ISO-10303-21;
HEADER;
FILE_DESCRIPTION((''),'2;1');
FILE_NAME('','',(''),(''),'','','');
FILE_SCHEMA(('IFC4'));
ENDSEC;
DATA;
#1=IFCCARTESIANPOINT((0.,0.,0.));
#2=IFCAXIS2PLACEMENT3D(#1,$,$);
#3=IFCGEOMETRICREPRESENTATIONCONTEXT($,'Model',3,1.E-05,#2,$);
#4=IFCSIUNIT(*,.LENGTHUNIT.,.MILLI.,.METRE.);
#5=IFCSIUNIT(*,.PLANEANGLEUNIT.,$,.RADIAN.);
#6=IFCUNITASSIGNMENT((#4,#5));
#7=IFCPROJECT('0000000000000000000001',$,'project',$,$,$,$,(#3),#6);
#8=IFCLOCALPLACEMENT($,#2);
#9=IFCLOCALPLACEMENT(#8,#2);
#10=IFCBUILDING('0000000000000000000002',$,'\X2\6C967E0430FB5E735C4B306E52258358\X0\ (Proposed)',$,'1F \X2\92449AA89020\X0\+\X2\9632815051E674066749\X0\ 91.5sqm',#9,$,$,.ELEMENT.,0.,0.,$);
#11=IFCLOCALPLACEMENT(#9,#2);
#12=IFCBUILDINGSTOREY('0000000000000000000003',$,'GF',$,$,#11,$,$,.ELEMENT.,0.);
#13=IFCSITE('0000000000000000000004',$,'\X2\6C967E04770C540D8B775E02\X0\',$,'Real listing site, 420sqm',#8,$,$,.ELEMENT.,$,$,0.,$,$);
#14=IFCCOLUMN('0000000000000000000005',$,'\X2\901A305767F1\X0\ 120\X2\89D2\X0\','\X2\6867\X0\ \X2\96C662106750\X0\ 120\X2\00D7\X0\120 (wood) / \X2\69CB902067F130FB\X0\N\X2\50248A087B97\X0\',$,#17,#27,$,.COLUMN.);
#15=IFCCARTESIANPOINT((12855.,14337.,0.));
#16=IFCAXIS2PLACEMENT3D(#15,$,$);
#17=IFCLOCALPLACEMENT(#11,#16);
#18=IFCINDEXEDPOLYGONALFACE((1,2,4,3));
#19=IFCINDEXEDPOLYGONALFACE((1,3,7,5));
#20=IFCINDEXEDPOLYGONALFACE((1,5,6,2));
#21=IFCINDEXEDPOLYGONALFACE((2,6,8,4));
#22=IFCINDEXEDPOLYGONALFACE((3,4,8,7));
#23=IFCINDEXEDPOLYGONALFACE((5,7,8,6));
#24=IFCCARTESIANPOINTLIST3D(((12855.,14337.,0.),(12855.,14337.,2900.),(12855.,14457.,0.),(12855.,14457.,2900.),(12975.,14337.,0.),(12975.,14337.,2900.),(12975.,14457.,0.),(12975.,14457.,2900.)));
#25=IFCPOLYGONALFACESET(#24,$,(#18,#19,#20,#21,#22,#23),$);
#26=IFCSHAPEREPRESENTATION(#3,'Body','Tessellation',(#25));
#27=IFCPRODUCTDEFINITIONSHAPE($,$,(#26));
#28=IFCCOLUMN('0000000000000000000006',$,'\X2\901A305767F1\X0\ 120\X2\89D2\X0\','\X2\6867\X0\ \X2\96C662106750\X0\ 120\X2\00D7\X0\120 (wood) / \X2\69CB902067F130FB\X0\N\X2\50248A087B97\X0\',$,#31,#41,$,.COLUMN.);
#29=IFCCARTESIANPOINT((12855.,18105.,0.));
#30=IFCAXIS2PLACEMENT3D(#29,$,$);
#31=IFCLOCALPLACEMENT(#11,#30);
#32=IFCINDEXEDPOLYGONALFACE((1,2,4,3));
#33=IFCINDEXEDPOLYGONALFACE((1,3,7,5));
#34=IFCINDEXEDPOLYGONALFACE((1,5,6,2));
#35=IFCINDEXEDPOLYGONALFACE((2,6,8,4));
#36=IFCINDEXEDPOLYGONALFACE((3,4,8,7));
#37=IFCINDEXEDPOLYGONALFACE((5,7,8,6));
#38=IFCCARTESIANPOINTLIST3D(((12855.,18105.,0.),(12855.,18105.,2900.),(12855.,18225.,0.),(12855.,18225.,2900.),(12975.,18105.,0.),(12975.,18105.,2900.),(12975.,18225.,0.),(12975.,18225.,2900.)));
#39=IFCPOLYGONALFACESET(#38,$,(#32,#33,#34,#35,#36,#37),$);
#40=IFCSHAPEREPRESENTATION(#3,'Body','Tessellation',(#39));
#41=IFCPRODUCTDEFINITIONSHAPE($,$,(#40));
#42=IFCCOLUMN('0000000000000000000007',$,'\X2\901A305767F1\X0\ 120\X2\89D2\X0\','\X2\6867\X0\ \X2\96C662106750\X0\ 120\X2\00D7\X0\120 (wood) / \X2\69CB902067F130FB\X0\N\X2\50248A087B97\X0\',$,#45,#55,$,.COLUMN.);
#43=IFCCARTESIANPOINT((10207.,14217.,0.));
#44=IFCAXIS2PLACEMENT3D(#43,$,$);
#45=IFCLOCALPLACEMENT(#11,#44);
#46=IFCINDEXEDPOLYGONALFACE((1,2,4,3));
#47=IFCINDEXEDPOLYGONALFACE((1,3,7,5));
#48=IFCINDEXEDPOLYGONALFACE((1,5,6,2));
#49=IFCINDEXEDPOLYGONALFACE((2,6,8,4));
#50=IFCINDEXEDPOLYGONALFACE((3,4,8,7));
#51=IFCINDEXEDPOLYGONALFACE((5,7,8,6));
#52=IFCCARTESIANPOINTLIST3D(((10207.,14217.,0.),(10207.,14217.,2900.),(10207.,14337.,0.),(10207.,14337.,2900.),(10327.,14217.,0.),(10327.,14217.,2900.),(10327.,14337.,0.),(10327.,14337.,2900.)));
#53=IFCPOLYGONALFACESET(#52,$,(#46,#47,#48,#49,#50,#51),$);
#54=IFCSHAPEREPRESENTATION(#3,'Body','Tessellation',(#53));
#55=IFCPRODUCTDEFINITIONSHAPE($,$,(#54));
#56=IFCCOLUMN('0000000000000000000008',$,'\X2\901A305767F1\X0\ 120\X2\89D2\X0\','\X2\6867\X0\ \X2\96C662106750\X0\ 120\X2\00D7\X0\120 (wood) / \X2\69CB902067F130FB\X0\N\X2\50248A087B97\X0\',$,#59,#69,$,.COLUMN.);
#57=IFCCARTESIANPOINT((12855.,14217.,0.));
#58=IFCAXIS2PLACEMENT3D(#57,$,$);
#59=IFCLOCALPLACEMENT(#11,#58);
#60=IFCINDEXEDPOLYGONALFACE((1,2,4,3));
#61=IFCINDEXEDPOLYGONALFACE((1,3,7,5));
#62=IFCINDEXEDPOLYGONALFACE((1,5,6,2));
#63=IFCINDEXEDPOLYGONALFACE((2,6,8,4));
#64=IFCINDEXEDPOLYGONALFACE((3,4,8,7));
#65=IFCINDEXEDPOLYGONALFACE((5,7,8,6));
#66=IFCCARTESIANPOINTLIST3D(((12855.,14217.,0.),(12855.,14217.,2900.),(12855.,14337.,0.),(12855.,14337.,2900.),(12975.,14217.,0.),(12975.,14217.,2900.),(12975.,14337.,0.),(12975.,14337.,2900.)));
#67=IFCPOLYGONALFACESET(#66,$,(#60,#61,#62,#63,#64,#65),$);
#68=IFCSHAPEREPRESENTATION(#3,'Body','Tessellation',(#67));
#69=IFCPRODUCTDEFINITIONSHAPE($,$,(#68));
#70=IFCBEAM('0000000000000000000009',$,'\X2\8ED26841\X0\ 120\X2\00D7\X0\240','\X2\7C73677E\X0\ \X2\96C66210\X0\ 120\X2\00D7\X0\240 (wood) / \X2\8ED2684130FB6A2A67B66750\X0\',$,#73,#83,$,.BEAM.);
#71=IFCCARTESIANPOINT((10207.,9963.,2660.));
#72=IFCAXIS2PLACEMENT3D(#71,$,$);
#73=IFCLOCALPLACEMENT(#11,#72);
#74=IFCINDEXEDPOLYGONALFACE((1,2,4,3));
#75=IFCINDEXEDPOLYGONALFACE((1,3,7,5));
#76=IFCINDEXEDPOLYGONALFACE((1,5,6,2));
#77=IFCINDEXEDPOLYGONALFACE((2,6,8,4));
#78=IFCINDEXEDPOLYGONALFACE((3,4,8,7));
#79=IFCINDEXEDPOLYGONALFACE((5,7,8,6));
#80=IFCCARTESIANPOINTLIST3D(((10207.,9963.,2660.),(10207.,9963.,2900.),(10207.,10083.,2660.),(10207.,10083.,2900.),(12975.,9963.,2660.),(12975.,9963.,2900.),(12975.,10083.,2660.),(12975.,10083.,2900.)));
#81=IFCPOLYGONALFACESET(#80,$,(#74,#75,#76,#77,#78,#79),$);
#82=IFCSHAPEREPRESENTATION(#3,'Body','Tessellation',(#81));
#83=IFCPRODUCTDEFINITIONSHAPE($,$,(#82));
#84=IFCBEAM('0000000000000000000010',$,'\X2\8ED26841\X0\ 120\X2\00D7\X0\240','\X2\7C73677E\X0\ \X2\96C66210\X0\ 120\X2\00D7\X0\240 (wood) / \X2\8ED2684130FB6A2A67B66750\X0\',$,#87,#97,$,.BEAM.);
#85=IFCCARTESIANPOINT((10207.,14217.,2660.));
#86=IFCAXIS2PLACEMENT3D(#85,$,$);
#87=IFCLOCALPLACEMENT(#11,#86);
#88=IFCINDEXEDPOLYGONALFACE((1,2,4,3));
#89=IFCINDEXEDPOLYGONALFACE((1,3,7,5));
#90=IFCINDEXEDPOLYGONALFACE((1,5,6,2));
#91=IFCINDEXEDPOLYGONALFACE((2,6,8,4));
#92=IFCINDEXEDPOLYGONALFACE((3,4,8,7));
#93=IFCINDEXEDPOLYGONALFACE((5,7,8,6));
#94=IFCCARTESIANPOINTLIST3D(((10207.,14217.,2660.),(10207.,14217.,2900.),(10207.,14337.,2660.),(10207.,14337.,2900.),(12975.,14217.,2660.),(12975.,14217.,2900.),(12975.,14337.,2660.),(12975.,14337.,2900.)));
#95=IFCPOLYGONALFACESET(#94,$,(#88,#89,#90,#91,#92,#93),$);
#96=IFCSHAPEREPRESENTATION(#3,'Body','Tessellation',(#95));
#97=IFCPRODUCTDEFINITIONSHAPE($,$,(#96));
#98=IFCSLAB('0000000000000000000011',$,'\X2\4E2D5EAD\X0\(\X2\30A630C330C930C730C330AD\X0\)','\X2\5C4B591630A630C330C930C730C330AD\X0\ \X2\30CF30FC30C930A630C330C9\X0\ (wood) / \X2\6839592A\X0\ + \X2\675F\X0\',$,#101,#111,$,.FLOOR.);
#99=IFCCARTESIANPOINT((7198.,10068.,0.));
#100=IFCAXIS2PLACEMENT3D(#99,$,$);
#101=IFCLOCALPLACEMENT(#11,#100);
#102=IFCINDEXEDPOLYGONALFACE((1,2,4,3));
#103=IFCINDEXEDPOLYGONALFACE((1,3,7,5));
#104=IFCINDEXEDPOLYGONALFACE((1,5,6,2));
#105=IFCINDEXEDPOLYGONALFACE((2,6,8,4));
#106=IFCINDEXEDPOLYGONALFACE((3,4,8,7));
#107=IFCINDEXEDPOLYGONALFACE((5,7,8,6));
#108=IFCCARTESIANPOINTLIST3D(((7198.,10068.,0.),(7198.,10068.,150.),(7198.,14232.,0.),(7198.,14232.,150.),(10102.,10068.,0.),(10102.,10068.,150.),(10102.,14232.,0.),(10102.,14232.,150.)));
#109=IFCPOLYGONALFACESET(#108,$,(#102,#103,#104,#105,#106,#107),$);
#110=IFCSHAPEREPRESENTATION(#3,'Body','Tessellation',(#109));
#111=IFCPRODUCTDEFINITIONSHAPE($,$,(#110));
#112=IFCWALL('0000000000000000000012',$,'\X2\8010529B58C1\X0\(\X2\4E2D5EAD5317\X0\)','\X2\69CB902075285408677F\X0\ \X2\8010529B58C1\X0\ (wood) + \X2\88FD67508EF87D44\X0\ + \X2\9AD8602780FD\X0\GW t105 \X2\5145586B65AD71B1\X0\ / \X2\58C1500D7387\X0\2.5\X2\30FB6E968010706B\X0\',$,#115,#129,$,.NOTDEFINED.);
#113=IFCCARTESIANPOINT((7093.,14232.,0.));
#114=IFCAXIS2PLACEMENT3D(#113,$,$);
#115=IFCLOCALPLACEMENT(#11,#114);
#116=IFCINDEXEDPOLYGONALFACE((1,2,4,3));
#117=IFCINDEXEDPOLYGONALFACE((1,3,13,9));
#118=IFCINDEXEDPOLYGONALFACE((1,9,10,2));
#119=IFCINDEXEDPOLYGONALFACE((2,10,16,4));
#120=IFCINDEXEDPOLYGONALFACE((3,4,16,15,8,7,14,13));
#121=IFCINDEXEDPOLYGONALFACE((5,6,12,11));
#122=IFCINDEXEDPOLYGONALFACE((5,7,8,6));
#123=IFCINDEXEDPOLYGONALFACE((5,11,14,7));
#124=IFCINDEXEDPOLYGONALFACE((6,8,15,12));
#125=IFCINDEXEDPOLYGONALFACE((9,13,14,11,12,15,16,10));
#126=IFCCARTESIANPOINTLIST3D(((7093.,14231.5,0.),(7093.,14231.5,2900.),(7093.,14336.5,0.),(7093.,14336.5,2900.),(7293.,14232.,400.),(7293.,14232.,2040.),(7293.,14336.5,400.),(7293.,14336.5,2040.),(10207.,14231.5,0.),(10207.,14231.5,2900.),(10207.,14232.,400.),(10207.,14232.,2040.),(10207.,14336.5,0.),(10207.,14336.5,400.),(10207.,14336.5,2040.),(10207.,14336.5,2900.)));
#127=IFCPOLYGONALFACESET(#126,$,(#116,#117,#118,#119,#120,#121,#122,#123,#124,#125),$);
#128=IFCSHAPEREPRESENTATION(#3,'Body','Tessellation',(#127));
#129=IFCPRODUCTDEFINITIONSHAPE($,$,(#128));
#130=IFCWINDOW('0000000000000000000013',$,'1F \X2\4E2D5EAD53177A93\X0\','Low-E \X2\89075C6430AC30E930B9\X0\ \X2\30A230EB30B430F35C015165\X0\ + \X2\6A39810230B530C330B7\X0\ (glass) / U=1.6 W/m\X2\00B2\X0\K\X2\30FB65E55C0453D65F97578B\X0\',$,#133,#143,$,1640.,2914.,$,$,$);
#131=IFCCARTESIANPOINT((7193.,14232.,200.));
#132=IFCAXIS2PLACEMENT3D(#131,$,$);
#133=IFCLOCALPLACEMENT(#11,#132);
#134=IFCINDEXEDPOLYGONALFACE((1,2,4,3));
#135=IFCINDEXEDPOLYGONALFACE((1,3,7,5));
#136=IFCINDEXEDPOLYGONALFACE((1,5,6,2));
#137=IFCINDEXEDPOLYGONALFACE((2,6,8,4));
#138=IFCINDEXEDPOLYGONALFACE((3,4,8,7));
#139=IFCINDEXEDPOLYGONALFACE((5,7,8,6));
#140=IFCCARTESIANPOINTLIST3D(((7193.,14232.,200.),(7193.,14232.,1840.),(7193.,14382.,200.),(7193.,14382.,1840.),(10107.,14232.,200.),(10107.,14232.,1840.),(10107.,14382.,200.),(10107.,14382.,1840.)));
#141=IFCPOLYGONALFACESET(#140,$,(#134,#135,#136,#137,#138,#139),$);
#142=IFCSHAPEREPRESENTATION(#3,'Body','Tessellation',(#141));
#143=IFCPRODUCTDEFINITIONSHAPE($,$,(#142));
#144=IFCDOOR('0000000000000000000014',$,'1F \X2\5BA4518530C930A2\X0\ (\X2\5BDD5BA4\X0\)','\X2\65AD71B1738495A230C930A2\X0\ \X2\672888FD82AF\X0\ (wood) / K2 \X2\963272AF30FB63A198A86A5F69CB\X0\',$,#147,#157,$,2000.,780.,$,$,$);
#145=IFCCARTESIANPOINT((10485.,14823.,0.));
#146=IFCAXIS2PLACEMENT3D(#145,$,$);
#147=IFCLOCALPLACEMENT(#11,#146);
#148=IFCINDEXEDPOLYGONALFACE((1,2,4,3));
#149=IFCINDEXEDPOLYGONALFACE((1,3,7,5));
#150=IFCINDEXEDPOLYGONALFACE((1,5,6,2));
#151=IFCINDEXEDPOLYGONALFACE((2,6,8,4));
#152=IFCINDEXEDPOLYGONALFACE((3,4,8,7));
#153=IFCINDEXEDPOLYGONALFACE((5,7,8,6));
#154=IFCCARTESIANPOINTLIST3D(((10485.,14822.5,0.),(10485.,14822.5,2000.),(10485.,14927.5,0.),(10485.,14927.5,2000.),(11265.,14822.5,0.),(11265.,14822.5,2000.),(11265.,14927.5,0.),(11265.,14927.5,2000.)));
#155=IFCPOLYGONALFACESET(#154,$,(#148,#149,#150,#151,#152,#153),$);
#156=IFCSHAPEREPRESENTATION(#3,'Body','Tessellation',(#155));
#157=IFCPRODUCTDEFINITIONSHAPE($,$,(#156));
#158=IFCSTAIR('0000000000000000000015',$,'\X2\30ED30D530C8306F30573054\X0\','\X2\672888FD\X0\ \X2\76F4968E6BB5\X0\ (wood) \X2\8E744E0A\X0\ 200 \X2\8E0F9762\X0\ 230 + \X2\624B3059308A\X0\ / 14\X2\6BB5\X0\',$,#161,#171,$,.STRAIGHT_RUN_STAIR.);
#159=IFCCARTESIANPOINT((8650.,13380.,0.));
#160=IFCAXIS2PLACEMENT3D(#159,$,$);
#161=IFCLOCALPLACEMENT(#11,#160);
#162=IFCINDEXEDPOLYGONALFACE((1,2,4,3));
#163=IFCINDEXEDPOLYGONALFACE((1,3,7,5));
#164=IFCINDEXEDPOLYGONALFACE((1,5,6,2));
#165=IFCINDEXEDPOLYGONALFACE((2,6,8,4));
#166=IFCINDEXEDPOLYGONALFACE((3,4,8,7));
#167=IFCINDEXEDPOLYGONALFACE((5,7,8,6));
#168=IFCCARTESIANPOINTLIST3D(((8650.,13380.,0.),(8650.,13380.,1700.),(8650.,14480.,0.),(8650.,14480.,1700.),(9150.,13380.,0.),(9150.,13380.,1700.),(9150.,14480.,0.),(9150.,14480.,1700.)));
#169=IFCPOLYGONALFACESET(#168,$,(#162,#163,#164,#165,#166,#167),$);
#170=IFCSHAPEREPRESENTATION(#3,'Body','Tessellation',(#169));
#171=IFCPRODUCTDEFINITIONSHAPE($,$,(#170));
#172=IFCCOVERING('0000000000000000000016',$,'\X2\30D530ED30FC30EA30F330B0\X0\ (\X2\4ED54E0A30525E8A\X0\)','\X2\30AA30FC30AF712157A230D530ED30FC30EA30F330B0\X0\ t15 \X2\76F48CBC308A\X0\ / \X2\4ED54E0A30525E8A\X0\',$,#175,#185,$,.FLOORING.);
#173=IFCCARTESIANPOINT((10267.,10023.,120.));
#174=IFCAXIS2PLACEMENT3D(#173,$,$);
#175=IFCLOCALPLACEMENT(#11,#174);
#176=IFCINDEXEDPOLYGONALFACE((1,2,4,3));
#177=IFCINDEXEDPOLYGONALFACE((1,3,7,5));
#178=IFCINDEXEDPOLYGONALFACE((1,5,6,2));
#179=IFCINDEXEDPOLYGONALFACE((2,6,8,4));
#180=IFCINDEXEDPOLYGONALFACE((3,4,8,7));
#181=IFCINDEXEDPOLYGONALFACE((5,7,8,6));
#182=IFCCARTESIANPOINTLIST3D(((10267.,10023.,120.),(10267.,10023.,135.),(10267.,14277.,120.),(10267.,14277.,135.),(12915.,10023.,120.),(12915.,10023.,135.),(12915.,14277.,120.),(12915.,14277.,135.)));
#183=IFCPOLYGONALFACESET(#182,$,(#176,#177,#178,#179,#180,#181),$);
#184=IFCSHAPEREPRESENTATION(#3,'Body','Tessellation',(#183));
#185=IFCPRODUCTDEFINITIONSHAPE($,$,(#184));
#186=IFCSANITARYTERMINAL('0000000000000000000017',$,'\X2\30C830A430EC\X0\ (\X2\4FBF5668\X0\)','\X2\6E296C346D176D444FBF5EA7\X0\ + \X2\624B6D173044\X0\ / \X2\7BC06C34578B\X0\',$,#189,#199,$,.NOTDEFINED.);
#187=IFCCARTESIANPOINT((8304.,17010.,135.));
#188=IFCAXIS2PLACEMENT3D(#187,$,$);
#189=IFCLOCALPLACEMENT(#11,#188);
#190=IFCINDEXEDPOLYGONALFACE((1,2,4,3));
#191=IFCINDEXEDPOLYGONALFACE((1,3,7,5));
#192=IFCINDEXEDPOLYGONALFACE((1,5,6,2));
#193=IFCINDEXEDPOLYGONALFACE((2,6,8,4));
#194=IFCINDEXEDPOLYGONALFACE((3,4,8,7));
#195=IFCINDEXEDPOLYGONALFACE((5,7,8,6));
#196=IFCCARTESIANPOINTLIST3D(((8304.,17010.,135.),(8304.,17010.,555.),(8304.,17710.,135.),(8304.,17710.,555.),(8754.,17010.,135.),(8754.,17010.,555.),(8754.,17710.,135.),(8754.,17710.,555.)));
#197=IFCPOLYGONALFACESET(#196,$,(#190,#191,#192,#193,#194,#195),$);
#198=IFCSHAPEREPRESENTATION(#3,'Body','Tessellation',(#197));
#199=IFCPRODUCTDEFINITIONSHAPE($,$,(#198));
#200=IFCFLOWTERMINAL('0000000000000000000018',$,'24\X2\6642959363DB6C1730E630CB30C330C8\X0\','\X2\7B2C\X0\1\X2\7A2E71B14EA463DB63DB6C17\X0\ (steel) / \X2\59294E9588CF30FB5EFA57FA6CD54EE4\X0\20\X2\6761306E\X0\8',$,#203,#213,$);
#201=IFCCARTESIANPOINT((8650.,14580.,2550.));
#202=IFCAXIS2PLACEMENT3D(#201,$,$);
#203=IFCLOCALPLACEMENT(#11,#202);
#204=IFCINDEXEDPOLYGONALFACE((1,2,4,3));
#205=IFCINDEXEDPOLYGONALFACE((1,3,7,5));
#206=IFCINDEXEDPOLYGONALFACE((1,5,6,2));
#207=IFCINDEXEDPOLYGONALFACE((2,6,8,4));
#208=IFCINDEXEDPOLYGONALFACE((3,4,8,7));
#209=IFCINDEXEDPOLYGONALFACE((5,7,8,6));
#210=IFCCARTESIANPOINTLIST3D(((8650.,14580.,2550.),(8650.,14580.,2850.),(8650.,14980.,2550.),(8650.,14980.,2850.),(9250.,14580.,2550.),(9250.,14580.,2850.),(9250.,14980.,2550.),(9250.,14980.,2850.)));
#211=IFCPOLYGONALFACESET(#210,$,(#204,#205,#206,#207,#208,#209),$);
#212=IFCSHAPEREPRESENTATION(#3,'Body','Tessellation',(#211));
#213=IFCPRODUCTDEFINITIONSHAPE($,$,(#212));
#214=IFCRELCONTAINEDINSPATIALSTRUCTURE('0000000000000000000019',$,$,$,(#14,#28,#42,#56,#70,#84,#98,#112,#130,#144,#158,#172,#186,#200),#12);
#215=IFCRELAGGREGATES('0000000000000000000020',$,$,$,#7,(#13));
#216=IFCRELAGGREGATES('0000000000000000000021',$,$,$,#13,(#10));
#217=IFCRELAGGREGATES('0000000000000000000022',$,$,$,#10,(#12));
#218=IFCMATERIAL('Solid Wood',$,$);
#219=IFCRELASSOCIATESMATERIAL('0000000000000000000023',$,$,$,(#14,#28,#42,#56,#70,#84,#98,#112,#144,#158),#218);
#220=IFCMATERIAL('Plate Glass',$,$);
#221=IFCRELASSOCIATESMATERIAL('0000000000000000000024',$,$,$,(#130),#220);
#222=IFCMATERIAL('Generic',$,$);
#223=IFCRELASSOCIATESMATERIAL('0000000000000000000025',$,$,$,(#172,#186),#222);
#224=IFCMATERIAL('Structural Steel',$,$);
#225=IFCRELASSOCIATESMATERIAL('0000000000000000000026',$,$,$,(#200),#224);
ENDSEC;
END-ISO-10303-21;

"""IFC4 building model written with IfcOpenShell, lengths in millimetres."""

from ifc_helpers import new_model, si_unit, frame, frame_2d, origin, place, context, project, spatial, rectangle, extrude, material, element, fill, save


model = new_model("IFC4")

# Units and contexts
model_context = context("Model", 3, precision=1e-05, world=origin())
ifc_project = project(units=[si_unit("LENGTHUNIT", "METRE", prefix="MILLI"), si_unit("PLANEANGLEUNIT", "RADIAN")], contexts=[model_context])

# Site, building, storey
site_placement = place(None, origin())
site = spatial("IfcSite", under=ifc_project, at=site_placement, Name="沖縄県名護市", ObjectType="Real listing site, 420sqm", CompositionType="ELEMENT", RefElevation=0.0)
building_placement = place(site_placement, origin())
building = spatial("IfcBuilding", under=site, at=building_placement, Name="沖縄・平屋の別荘 (Proposed)", ObjectType="1F 鉄骨造+防腐処理杉 91.5sqm", CompositionType="ELEMENT", ElevationOfRefHeight=0.0, ElevationOfTerrain=0.0)
storey_placement = place(building_placement, origin())
storey = spatial("IfcBuildingStorey", under=building, at=storey_placement, Name="GF", CompositionType="ELEMENT", Elevation=0.0)

# Columns
ifc_material_1 = material(Name="Solid Wood")
column_1_placement = place(storey_placement, frame((12855.0, 14337.0, 0.0)))
element("IfcColumn", 1, at=column_1_placement, inside=storey, material=ifc_material_1, Name="通し柱 120角", Description="桧 集成材 120×120 (wood) / 構造柱・N値計算", PredefinedType="COLUMN", context=model_context, shape_type="SweptSolid", body=[
    extrude(rectangle(XDim=120.0, YDim=120.0, at=frame_2d((60.0, 60.0))), frame((12855.0, 14337.0, 0.0)), (0.0, 0.0, 1.0), 2900.0),
])
column_2_placement = place(storey_placement, frame((12855.0, 18105.0, 0.0)))
element("IfcColumn", 2, at=column_2_placement, inside=storey, material=ifc_material_1, Name="通し柱 120角", Description="桧 集成材 120×120 (wood) / 構造柱・N値計算", PredefinedType="COLUMN", context=model_context, shape_type="SweptSolid", body=[
    extrude(rectangle(XDim=120.0, YDim=120.0, at=frame_2d((60.0, 60.0))), frame((12855.0, 18105.0, 0.0)), (0.0, 0.0, 1.0), 2900.0),
])
column_3_placement = place(storey_placement, frame((10207.0, 14217.0, 0.0)))
element("IfcColumn", 3, at=column_3_placement, inside=storey, material=ifc_material_1, Name="通し柱 120角", Description="桧 集成材 120×120 (wood) / 構造柱・N値計算", PredefinedType="COLUMN", context=model_context, shape_type="SweptSolid", body=[
    extrude(rectangle(XDim=120.0, YDim=120.0, at=frame_2d((60.0, 60.0))), frame((10207.0, 14217.0, 0.0)), (0.0, 0.0, 1.0), 2900.0),
])
column_4_placement = place(storey_placement, frame((12855.0, 14217.0, 0.0)))
element("IfcColumn", 4, at=column_4_placement, inside=storey, material=ifc_material_1, Name="通し柱 120角", Description="桧 集成材 120×120 (wood) / 構造柱・N値計算", PredefinedType="COLUMN", context=model_context, shape_type="SweptSolid", body=[
    extrude(rectangle(XDim=120.0, YDim=120.0, at=frame_2d((60.0, 60.0))), frame((12855.0, 14217.0, 0.0)), (0.0, 0.0, 1.0), 2900.0),
])

# Beams
beam_1_placement = place(storey_placement, frame((10207.0, 9963.0, 2660.0)))
element("IfcBeam", 5, at=beam_1_placement, inside=storey, material=ifc_material_1, Name="軒桁 120×240", Description="米松 集成 120×240 (wood) / 軒桁・横架材", PredefinedType="BEAM", context=model_context, shape_type="SweptSolid", body=[
    extrude(rectangle(XDim=2768.0, YDim=120.0, at=frame_2d((1384.0, 60.0))), frame((10207.0, 9963.0, 2660.0)), (0.0, 0.0, 1.0), 240.0),
])
beam_2_placement = place(storey_placement, frame((10207.0, 14217.0, 2660.0)))
element("IfcBeam", 6, at=beam_2_placement, inside=storey, material=ifc_material_1, Name="軒桁 120×240", Description="米松 集成 120×240 (wood) / 軒桁・横架材", PredefinedType="BEAM", context=model_context, shape_type="SweptSolid", body=[
    extrude(rectangle(XDim=2768.0, YDim=120.0, at=frame_2d((1384.0, 60.0))), frame((10207.0, 14217.0, 2660.0)), (0.0, 0.0, 1.0), 240.0),
])

# Slab
slab_placement = place(storey_placement, frame((7198.0, 10068.0, 0.0)))
element("IfcSlab", 7, at=slab_placement, inside=storey, material=ifc_material_1, Name="中庭(ウッドデッキ)", Description="屋外ウッドデッキ ハードウッド (wood) / 根太 + 束", PredefinedType="FLOOR", context=model_context, shape_type="SweptSolid", body=[
    extrude(rectangle(XDim=2904.0, YDim=4164.0, at=frame_2d((1452.0, 2082.0))), frame((7198.0, 10068.0, 0.0)), (0.0, 0.0, 1.0), 150.0),
])

# Wall, opening, window
wall_1_placement = place(storey_placement, frame((7093.0, 14232.0, 0.0)))
wall_1 = element("IfcWall", 8, at=wall_1_placement, inside=storey, material=ifc_material_1, Name="耐力壁(中庭北)", Description="構造用合板 耐力壁 (wood) + 製材軸組 + 高性能GW t105 充填断熱 / 壁倍率2.5・準耐火", PredefinedType="NOTDEFINED", context=model_context, shape_type="SweptSolid", body=[
    extrude(rectangle(XDim=3114.0, YDim=105.0, at=frame_2d((1557.0, 52.0))), frame((7093.0, 14232.0, 0.0)), (0.0, 0.0, 1.0), 2900.0),
])
opening_placement = place(storey_placement, frame((7193.0, 14232.0, 200.0)))
opening = element("IfcOpeningElement", 9, at=opening_placement, cuts=wall_1, PredefinedType="NOTDEFINED", context=model_context, shape_type="SweptSolid", body=[
    extrude(rectangle(XDim=2914.0, YDim=150.0, at=frame_2d((1457.0, 75.0))), frame((7193.0, 14232.0, 200.0)), (0.0, 0.0, 1.0), 1640.0),
])
ifc_material_2 = material(Name="Plate Glass")
window_placement = place(storey_placement, frame((7193.0, 14232.0, 200.0)))
window = element("IfcWindow", 10, at=window_placement, inside=storey, material=ifc_material_2, Name="1F 中庭北窓", Description="Low-E 複層ガラス アルゴン封入 + 樹脂サッシ (glass) / U=1.6 W/m²K・日射取得型", OverallHeight=1640.0, OverallWidth=2914.0, context=model_context, shape_type="SweptSolid", body=[
    extrude(rectangle(XDim=2914.0, YDim=150.0, at=frame_2d((1457.0, 75.0))), frame((7193.0, 14232.0, 200.0)), (0.0, 0.0, 1.0), 1640.0),
])
fill(opening, window)

# Door
door_placement = place(storey_placement, frame((10485.0, 14823.0, 0.0)))
element("IfcDoor", 11, at=door_placement, inside=storey, material=ifc_material_1, Name="1F 室内ドア (寝室)", Description="断熱玄関ドア 木製芯 (wood) / K2 防犯・採風機構", OverallHeight=2000.0, OverallWidth=780.0, context=model_context, shape_type="SweptSolid", body=[
    extrude(rectangle(XDim=780.0, YDim=105.0, at=frame_2d((390.0, 52.0))), frame((10485.0, 14823.0, 0.0)), (0.0, 0.0, 1.0), 2000.0),
])

# Stair
stair_placement = place(storey_placement, frame((8650.0, 13380.0, 0.0)))
element("IfcStair", 12, at=stair_placement, inside=storey, material=ifc_material_1, Name="ロフトはしご", Description="木製 直階段 (wood) 蹴上 200 踏面 230 + 手すり / 14段", PredefinedType="STRAIGHT_RUN_STAIR", context=model_context, shape_type="SweptSolid", body=[
    extrude(rectangle(XDim=500.0, YDim=1100.0, at=frame_2d((250.0, 550.0))), frame((8650.0, 13380.0, 0.0)), (0.0, 0.0, 1.0), 1700.0),
])

# Covering
ifc_material_3 = material(Name="Generic")
covering_placement = place(storey_placement, frame((10267.0, 10023.0, 120.0)))
element("IfcCovering", 13, at=covering_placement, inside=storey, material=ifc_material_3, Name="フローリング (仕上げ床)", Description="オーク無垢フローリング t15 直貼り / 仕上げ床", PredefinedType="FLOORING", context=model_context, shape_type="SweptSolid", body=[
    extrude(rectangle(XDim=2648.0, YDim=4254.0, at=frame_2d((1324.0, 2127.0))), frame((10267.0, 10023.0, 120.0)), (0.0, 0.0, 1.0), 15.0),
])

# Sanitary terminal
sanitary_terminal_placement = place(storey_placement, frame((8304.0, 17010.0, 135.0)))
element("IfcSanitaryTerminal", 14, at=sanitary_terminal_placement, inside=storey, material=ifc_material_3, Name="トイレ (便器)", Description="温水洗浄便座 + 手洗い / 節水型", PredefinedType="NOTDEFINED", context=model_context, shape_type="SweptSolid", body=[
    extrude(rectangle(XDim=450.0, YDim=700.0, at=frame_2d((225.0, 350.0))), frame((8304.0, 17010.0, 135.0)), (0.0, 0.0, 1.0), 420.0),
])

# Flow terminal
ifc_material_4 = material(Name="Structural Steel")
flow_terminal_placement = place(storey_placement, frame((8650.0, 14580.0, 2550.0)))
element("IfcFlowTerminal", 15, at=flow_terminal_placement, inside=storey, material=ifc_material_4, Name="24時間換気ユニット", Description="第1種熱交換換気 (steel) / 天井裏・建基法令20条の8", context=model_context, shape_type="SweptSolid", body=[
    extrude(rectangle(XDim=600.0, YDim=400.0, at=frame_2d((300.0, 200.0))), frame((8650.0, 14580.0, 2550.0)), (0.0, 0.0, 1.0), 300.0),
])

save(model, "model.ifc")
